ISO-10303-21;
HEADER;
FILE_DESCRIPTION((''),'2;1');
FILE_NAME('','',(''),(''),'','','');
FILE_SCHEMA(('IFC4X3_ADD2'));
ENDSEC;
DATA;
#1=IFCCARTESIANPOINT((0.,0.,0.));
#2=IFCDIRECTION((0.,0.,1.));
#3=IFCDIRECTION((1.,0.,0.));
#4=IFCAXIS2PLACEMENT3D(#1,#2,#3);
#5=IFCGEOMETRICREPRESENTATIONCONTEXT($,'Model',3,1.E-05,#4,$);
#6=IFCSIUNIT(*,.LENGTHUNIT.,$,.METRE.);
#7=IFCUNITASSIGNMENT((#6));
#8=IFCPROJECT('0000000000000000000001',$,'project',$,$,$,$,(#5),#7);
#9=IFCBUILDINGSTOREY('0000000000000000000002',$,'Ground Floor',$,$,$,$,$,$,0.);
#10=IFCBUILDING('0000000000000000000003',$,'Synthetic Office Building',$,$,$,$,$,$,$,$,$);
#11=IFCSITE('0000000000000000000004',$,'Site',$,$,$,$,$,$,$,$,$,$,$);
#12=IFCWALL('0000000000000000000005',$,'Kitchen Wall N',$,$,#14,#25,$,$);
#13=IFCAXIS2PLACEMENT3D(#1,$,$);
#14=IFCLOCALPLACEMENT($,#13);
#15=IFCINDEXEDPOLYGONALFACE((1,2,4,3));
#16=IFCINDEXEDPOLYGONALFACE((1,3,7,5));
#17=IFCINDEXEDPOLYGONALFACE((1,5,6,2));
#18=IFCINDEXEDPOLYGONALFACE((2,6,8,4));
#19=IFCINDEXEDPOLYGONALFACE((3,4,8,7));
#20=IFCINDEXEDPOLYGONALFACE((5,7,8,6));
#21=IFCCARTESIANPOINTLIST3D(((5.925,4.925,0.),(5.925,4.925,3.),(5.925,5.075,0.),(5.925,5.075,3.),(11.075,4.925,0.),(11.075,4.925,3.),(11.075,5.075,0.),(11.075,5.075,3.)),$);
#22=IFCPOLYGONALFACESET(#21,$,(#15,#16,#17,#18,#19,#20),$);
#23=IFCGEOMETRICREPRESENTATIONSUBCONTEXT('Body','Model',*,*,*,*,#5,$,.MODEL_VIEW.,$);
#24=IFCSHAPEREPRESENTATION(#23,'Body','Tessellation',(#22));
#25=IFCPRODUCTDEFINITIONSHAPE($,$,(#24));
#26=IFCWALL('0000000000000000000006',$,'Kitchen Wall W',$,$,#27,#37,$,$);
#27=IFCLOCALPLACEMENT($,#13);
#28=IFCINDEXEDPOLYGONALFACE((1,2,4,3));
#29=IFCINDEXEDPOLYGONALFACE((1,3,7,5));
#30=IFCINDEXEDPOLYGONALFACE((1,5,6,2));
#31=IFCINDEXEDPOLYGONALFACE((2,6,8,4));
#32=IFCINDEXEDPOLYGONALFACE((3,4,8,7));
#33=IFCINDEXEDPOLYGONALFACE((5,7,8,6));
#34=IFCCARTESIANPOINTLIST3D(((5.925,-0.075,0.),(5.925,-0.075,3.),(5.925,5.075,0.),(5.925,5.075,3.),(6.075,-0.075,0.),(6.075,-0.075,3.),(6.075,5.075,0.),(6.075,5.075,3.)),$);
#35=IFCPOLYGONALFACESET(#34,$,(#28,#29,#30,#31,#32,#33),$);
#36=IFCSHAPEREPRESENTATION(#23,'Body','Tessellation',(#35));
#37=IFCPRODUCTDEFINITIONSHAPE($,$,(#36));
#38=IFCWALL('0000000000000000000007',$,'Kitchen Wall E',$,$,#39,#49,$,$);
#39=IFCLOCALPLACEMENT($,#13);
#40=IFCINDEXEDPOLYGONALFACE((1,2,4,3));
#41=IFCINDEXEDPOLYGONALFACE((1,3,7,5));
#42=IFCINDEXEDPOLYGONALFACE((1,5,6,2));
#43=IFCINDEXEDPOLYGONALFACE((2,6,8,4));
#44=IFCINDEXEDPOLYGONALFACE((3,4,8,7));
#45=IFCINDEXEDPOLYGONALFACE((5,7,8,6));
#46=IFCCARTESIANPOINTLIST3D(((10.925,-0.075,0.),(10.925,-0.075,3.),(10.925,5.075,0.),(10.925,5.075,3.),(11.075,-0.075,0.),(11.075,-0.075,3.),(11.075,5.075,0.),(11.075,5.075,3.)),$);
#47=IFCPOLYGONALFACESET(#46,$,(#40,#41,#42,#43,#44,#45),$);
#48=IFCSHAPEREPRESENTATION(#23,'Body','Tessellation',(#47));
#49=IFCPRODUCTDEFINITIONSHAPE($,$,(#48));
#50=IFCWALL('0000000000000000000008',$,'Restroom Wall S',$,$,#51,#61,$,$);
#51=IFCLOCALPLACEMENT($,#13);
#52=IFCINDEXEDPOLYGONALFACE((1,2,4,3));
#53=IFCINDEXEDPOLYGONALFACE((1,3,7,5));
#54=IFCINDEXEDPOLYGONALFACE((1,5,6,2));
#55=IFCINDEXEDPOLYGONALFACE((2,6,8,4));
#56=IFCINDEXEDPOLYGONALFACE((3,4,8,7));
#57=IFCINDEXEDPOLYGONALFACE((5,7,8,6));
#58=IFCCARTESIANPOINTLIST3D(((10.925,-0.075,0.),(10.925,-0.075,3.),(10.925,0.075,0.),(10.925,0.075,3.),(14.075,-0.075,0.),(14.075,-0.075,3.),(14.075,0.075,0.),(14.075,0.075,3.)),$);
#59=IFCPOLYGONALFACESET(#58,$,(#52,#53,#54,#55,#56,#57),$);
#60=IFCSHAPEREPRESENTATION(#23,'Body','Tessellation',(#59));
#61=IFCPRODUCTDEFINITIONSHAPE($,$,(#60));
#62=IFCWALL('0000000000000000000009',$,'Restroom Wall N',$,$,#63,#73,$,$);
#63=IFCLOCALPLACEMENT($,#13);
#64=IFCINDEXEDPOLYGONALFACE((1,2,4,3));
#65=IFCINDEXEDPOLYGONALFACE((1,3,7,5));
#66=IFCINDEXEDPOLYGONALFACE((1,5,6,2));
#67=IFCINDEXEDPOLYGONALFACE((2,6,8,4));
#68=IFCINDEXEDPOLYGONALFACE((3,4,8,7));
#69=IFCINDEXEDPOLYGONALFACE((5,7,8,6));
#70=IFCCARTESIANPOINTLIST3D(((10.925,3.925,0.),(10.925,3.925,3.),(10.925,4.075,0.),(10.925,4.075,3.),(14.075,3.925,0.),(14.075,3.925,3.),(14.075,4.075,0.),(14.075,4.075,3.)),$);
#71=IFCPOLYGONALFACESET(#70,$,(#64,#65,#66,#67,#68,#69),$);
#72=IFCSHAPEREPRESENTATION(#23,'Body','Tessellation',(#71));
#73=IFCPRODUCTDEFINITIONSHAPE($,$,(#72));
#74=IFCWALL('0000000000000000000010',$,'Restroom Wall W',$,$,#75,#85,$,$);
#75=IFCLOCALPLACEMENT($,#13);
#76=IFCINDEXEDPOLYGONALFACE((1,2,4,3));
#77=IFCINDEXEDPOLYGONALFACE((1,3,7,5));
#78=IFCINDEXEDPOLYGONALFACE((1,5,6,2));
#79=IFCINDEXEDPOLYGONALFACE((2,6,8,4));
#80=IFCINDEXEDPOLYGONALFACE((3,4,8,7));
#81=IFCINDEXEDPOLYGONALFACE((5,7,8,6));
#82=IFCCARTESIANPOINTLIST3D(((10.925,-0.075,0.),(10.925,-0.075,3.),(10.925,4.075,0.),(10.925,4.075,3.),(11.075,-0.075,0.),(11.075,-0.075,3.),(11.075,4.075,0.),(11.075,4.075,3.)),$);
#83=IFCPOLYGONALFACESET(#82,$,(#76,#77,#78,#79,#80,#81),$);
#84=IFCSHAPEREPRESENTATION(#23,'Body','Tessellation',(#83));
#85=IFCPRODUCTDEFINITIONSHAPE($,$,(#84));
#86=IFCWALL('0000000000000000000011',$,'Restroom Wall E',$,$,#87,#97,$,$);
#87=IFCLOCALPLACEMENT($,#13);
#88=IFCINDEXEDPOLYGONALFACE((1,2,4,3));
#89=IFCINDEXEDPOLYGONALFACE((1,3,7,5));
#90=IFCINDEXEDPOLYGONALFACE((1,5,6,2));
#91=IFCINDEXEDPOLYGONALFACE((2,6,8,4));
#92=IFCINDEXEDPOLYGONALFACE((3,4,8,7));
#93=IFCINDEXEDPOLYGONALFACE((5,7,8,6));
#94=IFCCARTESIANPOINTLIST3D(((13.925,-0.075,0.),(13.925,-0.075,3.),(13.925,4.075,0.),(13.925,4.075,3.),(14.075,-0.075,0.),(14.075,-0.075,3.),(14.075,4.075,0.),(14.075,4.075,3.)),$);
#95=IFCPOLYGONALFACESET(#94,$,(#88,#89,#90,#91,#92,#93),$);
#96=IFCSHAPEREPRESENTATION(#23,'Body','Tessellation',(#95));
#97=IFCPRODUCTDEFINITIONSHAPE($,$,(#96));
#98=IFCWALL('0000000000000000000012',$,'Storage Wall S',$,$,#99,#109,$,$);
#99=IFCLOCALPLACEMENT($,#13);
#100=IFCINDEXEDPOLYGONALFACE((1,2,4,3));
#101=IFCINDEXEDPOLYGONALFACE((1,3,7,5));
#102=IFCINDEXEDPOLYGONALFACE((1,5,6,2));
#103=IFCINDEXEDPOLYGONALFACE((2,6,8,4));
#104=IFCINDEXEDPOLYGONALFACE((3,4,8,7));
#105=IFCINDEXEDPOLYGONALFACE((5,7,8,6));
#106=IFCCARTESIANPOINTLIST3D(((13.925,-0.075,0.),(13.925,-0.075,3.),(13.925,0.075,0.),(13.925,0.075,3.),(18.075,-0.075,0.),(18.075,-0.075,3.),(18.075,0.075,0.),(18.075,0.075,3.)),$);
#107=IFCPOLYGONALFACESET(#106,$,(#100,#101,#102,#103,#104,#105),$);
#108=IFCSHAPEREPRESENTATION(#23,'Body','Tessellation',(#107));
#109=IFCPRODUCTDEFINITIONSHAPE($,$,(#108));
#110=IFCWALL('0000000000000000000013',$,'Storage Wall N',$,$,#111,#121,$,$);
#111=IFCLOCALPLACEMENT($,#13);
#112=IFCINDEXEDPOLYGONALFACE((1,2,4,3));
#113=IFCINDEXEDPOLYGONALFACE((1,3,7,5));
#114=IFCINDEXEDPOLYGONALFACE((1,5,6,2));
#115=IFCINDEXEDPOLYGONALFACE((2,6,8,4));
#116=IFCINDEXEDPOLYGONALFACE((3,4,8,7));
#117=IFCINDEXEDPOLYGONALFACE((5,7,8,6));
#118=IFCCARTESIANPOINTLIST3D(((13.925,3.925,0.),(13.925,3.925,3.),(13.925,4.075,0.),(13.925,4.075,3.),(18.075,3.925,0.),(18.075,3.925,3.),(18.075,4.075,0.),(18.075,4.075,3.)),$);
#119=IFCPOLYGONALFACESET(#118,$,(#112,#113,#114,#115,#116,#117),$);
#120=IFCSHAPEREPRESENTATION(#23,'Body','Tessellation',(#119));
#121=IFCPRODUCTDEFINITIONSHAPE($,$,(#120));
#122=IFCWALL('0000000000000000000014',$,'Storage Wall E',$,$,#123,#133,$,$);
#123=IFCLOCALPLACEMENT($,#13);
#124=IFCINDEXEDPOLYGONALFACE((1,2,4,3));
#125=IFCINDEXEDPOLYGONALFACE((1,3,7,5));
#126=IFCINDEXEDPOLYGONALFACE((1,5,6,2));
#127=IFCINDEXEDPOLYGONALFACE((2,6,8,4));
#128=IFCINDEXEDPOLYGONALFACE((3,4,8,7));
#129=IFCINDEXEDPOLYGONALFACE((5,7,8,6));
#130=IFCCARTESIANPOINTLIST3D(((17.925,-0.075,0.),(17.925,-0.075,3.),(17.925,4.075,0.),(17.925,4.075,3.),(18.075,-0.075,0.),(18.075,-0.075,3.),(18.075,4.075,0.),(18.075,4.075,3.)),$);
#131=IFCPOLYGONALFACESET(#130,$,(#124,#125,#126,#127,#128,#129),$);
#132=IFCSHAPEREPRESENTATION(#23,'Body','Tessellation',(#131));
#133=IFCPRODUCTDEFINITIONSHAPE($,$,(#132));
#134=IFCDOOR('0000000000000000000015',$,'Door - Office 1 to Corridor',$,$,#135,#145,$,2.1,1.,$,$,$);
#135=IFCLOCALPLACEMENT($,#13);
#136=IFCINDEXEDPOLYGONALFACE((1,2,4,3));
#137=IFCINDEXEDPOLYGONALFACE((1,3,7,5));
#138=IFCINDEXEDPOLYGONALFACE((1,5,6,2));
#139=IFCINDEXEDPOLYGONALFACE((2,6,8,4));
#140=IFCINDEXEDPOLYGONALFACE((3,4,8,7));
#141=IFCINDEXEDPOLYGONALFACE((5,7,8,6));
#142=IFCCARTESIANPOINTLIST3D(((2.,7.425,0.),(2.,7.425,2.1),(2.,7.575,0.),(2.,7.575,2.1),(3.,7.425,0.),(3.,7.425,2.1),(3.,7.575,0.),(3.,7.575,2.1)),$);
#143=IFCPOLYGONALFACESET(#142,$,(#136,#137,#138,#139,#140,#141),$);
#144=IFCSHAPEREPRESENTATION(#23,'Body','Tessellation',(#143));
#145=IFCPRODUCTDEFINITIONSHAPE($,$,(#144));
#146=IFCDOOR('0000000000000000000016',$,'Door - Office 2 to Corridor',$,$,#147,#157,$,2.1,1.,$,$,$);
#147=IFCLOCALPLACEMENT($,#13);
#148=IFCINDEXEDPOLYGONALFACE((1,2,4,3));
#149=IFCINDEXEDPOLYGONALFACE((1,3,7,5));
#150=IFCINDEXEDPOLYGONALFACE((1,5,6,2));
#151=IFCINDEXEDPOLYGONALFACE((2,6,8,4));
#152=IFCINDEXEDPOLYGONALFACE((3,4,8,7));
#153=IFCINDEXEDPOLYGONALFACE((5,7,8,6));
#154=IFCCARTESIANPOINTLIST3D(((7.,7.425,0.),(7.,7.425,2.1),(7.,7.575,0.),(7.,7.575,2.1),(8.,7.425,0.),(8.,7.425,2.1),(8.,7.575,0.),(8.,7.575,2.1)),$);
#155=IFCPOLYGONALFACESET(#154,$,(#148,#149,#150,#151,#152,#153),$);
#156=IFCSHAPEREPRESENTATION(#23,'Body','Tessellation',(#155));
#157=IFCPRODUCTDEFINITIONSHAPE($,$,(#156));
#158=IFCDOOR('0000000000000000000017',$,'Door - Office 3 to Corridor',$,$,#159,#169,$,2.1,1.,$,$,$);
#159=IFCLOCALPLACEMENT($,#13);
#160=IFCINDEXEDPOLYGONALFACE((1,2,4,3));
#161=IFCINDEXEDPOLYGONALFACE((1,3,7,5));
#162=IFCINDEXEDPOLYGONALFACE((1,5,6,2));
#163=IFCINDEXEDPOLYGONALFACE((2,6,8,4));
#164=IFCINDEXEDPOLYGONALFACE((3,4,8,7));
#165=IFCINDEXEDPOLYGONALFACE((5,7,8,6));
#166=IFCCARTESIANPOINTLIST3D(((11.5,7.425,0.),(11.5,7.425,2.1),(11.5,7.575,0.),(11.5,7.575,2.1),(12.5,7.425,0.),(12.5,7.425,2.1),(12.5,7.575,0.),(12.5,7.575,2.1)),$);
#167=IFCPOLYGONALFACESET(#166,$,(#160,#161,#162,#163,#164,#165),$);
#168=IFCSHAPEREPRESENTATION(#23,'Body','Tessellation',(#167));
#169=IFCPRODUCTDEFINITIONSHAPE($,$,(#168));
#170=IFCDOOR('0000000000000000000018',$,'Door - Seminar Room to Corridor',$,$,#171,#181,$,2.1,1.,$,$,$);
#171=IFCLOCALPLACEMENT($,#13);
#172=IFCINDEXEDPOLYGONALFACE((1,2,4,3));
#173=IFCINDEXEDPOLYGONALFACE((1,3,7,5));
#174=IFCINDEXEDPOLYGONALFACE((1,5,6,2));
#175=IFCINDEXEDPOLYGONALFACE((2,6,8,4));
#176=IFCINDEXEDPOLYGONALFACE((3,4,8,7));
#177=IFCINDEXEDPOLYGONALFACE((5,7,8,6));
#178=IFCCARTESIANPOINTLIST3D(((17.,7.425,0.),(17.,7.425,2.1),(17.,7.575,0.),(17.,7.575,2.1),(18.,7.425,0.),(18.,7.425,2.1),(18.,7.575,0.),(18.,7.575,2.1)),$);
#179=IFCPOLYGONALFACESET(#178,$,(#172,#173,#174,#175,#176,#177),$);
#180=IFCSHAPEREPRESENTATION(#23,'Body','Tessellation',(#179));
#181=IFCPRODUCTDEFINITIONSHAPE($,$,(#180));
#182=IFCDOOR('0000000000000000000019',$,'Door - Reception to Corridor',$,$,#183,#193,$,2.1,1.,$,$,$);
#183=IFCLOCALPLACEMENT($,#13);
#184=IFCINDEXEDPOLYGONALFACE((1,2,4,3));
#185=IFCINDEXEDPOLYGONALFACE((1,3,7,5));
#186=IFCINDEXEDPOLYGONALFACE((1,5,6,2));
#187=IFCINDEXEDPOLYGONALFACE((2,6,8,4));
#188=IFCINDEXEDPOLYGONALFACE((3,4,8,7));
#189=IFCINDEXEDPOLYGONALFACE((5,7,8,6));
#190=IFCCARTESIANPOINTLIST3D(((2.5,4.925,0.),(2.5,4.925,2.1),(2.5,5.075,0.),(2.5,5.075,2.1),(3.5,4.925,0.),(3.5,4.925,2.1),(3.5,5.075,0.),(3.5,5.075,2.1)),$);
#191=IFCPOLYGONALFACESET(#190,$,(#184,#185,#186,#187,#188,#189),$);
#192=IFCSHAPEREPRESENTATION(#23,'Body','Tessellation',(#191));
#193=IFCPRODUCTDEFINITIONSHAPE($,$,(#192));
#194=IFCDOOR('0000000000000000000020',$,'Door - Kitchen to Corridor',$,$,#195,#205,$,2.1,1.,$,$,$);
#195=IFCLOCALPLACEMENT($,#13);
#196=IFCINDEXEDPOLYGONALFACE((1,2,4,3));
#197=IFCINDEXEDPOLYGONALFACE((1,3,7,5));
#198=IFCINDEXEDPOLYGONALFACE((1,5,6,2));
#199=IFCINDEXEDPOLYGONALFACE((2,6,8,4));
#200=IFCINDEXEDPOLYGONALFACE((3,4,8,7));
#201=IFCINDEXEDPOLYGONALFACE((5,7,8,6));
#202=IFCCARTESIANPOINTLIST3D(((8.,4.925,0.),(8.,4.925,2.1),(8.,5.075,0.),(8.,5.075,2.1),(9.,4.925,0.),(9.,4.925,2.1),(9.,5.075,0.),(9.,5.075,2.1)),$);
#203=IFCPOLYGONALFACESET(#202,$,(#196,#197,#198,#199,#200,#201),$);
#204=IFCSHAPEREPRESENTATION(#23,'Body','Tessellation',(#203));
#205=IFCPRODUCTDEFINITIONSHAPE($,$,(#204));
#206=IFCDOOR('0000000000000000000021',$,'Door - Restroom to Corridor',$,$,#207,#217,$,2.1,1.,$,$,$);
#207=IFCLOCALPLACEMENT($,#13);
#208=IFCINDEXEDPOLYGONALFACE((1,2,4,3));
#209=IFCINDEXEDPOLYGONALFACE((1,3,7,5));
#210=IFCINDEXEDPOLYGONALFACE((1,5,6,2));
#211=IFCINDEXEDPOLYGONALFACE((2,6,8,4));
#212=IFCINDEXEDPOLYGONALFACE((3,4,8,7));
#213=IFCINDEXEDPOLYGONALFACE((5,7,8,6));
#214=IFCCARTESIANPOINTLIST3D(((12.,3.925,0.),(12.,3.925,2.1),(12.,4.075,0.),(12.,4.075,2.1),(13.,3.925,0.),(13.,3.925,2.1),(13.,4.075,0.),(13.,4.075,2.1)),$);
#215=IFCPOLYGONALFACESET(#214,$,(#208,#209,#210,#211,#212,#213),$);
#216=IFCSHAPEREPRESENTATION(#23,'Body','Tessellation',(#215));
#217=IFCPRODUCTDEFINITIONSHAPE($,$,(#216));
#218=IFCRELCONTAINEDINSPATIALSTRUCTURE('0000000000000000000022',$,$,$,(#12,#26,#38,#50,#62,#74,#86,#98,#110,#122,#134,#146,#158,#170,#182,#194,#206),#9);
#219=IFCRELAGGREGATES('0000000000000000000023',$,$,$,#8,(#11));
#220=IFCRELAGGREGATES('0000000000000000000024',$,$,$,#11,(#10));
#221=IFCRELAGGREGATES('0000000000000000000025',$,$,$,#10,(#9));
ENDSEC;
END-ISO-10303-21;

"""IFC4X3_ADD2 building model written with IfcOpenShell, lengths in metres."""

from ifc_helpers import new_model, si_unit, origin_with_axes, place, context, subcontext, project, spatial, polyline, outline, extrude, element, save


model = new_model("IFC4X3_ADD2")

# Units and contexts
model_context = context("Model", 3, precision=1e-05, world=origin_with_axes())
body_context = subcontext(model_context, "Body", "Model", "MODEL_VIEW")
ifc_project = project(units=[si_unit("LENGTHUNIT", "METRE")], contexts=[model_context])

# Site, building, storey
site = spatial("IfcSite", under=ifc_project, Name="Site")
building = spatial("IfcBuilding", under=site, Name="Synthetic Office Building")
storey = spatial("IfcBuildingStorey", under=building, Name="Ground Floor", Elevation=0.0)

# Walls
wall_1_placement = place(None, origin_with_axes())
element("IfcWall", 1, at=wall_1_placement, inside=storey, Name="Kitchen Wall N", context=body_context, shape_type="SweptSolid", body=[
    extrude(outline(polyline([(5.925, 4.925), (11.075, 4.925), (11.075, 5.075), (5.925, 5.075), (5.925, 4.925)])), origin_with_axes(), (0.0, 0.0, 1.0), 3.0),
])
wall_2_placement = place(None, origin_with_axes())
element("IfcWall", 2, at=wall_2_placement, inside=storey, Name="Kitchen Wall W", context=body_context, shape_type="SweptSolid", body=[
    extrude(outline(polyline([(5.925, -0.075), (6.075, -0.075), (6.075, 5.075), (5.925, 5.075), (5.925, -0.075)])), origin_with_axes(), (0.0, 0.0, 1.0), 3.0),
])
wall_3_placement = place(None, origin_with_axes())
element("IfcWall", 3, at=wall_3_placement, inside=storey, Name="Kitchen Wall E", context=body_context, shape_type="SweptSolid", body=[
    extrude(outline(polyline([(10.925, -0.075), (11.075, -0.075), (11.075, 5.075), (10.925, 5.075), (10.925, -0.075)])), origin_with_axes(), (0.0, 0.0, 1.0), 3.0),
])
wall_4_placement = place(None, origin_with_axes())
element("IfcWall", 4, at=wall_4_placement, inside=storey, Name="Restroom Wall S", context=body_context, shape_type="SweptSolid", body=[
    extrude(outline(polyline([(10.925, -0.075), (14.075, -0.075), (14.075, 0.075), (10.925, 0.075), (10.925, -0.075)])), origin_with_axes(), (0.0, 0.0, 1.0), 3.0),
])
wall_5_placement = place(None, origin_with_axes())
element("IfcWall", 5, at=wall_5_placement, inside=storey, Name="Restroom Wall N", context=body_context, shape_type="SweptSolid", body=[
    extrude(outline(polyline([(10.925, 3.925), (14.075, 3.925), (14.075, 4.075), (10.925, 4.075), (10.925, 3.925)])), origin_with_axes(), (0.0, 0.0, 1.0), 3.0),
])
wall_6_placement = place(None, origin_with_axes())
element("IfcWall", 6, at=wall_6_placement, inside=storey, Name="Restroom Wall W", context=body_context, shape_type="SweptSolid", body=[
    extrude(outline(polyline([(10.925, -0.075), (11.075, -0.075), (11.075, 4.075), (10.925, 4.075), (10.925, -0.075)])), origin_with_axes(), (0.0, 0.0, 1.0), 3.0),
])
wall_7_placement = place(None, origin_with_axes())
element("IfcWall", 7, at=wall_7_placement, inside=storey, Name="Restroom Wall E", context=body_context, shape_type="SweptSolid", body=[
    extrude(outline(polyline([(13.925, -0.075), (14.075, -0.075), (14.075, 4.075), (13.925, 4.075), (13.925, -0.075)])), origin_with_axes(), (0.0, 0.0, 1.0), 3.0),
])
wall_8_placement = place(None, origin_with_axes())
element("IfcWall", 8, at=wall_8_placement, inside=storey, Name="Storage Wall S", context=body_context, shape_type="SweptSolid", body=[
    extrude(outline(polyline([(13.925, -0.075), (18.075, -0.075), (18.075, 0.075), (13.925, 0.075), (13.925, -0.075)])), origin_with_axes(), (0.0, 0.0, 1.0), 3.0),
])
wall_9_placement = place(None, origin_with_axes())
element("IfcWall", 9, at=wall_9_placement, inside=storey, Name="Storage Wall N", context=body_context, shape_type="SweptSolid", body=[
    extrude(outline(polyline([(13.925, 3.925), (18.075, 3.925), (18.075, 4.075), (13.925, 4.075), (13.925, 3.925)])), origin_with_axes(), (0.0, 0.0, 1.0), 3.0),
])
wall_10_placement = place(None, origin_with_axes())
element("IfcWall", 10, at=wall_10_placement, inside=storey, Name="Storage Wall E", context=body_context, shape_type="SweptSolid", body=[
    extrude(outline(polyline([(17.925, -0.075), (18.075, -0.075), (18.075, 4.075), (17.925, 4.075), (17.925, -0.075)])), origin_with_axes(), (0.0, 0.0, 1.0), 3.0),
])

# Doors
door_1_placement = place(None, origin_with_axes())
element("IfcDoor", 11, at=door_1_placement, inside=storey, Name="Door - Office 1 to Corridor", OverallHeight=2.1, OverallWidth=1.0, context=body_context, shape_type="SweptSolid", body=[
    extrude(outline(polyline([(2.0, 7.425), (3.0, 7.425), (3.0, 7.575), (2.0, 7.575), (2.0, 7.425)])), origin_with_axes(), (0.0, 0.0, 1.0), 2.1),
])
door_2_placement = place(None, origin_with_axes())
element("IfcDoor", 12, at=door_2_placement, inside=storey, Name="Door - Office 2 to Corridor", OverallHeight=2.1, OverallWidth=1.0, context=body_context, shape_type="SweptSolid", body=[
    extrude(outline(polyline([(7.0, 7.425), (8.0, 7.425), (8.0, 7.575), (7.0, 7.575), (7.0, 7.425)])), origin_with_axes(), (0.0, 0.0, 1.0), 2.1),
])
door_3_placement = place(None, origin_with_axes())
element("IfcDoor", 13, at=door_3_placement, inside=storey, Name="Door - Office 3 to Corridor", OverallHeight=2.1, OverallWidth=1.0, context=body_context, shape_type="SweptSolid", body=[
    extrude(outline(polyline([(11.5, 7.425), (12.5, 7.425), (12.5, 7.575), (11.5, 7.575), (11.5, 7.425)])), origin_with_axes(), (0.0, 0.0, 1.0), 2.1),
])
door_4_placement = place(None, origin_with_axes())
element("IfcDoor", 14, at=door_4_placement, inside=storey, Name="Door - Seminar Room to Corridor", OverallHeight=2.1, OverallWidth=1.0, context=body_context, shape_type="SweptSolid", body=[
    extrude(outline(polyline([(17.0, 7.425), (18.0, 7.425), (18.0, 7.575), (17.0, 7.575), (17.0, 7.425)])), origin_with_axes(), (0.0, 0.0, 1.0), 2.1),
])
door_5_placement = place(None, origin_with_axes())
element("IfcDoor", 15, at=door_5_placement, inside=storey, Name="Door - Reception to Corridor", OverallHeight=2.1, OverallWidth=1.0, context=body_context, shape_type="SweptSolid", body=[
    extrude(outline(polyline([(2.5, 4.925), (3.5, 4.925), (3.5, 5.075), (2.5, 5.075), (2.5, 4.925)])), origin_with_axes(), (0.0, 0.0, 1.0), 2.1),
])
door_6_placement = place(None, origin_with_axes())
element("IfcDoor", 16, at=door_6_placement, inside=storey, Name="Door - Kitchen to Corridor", OverallHeight=2.1, OverallWidth=1.0, context=body_context, shape_type="SweptSolid", body=[
    extrude(outline(polyline([(8.0, 4.925), (9.0, 4.925), (9.0, 5.075), (8.0, 5.075), (8.0, 4.925)])), origin_with_axes(), (0.0, 0.0, 1.0), 2.1),
])
door_7_placement = place(None, origin_with_axes())
element("IfcDoor", 17, at=door_7_placement, inside=storey, Name="Door - Restroom to Corridor", OverallHeight=2.1, OverallWidth=1.0, context=body_context, shape_type="SweptSolid", body=[
    extrude(outline(polyline([(12.0, 3.925), (13.0, 3.925), (13.0, 4.075), (12.0, 4.075), (12.0, 3.925)])), origin_with_axes(), (0.0, 0.0, 1.0), 2.1),
])

save(model, "model.ifc")
